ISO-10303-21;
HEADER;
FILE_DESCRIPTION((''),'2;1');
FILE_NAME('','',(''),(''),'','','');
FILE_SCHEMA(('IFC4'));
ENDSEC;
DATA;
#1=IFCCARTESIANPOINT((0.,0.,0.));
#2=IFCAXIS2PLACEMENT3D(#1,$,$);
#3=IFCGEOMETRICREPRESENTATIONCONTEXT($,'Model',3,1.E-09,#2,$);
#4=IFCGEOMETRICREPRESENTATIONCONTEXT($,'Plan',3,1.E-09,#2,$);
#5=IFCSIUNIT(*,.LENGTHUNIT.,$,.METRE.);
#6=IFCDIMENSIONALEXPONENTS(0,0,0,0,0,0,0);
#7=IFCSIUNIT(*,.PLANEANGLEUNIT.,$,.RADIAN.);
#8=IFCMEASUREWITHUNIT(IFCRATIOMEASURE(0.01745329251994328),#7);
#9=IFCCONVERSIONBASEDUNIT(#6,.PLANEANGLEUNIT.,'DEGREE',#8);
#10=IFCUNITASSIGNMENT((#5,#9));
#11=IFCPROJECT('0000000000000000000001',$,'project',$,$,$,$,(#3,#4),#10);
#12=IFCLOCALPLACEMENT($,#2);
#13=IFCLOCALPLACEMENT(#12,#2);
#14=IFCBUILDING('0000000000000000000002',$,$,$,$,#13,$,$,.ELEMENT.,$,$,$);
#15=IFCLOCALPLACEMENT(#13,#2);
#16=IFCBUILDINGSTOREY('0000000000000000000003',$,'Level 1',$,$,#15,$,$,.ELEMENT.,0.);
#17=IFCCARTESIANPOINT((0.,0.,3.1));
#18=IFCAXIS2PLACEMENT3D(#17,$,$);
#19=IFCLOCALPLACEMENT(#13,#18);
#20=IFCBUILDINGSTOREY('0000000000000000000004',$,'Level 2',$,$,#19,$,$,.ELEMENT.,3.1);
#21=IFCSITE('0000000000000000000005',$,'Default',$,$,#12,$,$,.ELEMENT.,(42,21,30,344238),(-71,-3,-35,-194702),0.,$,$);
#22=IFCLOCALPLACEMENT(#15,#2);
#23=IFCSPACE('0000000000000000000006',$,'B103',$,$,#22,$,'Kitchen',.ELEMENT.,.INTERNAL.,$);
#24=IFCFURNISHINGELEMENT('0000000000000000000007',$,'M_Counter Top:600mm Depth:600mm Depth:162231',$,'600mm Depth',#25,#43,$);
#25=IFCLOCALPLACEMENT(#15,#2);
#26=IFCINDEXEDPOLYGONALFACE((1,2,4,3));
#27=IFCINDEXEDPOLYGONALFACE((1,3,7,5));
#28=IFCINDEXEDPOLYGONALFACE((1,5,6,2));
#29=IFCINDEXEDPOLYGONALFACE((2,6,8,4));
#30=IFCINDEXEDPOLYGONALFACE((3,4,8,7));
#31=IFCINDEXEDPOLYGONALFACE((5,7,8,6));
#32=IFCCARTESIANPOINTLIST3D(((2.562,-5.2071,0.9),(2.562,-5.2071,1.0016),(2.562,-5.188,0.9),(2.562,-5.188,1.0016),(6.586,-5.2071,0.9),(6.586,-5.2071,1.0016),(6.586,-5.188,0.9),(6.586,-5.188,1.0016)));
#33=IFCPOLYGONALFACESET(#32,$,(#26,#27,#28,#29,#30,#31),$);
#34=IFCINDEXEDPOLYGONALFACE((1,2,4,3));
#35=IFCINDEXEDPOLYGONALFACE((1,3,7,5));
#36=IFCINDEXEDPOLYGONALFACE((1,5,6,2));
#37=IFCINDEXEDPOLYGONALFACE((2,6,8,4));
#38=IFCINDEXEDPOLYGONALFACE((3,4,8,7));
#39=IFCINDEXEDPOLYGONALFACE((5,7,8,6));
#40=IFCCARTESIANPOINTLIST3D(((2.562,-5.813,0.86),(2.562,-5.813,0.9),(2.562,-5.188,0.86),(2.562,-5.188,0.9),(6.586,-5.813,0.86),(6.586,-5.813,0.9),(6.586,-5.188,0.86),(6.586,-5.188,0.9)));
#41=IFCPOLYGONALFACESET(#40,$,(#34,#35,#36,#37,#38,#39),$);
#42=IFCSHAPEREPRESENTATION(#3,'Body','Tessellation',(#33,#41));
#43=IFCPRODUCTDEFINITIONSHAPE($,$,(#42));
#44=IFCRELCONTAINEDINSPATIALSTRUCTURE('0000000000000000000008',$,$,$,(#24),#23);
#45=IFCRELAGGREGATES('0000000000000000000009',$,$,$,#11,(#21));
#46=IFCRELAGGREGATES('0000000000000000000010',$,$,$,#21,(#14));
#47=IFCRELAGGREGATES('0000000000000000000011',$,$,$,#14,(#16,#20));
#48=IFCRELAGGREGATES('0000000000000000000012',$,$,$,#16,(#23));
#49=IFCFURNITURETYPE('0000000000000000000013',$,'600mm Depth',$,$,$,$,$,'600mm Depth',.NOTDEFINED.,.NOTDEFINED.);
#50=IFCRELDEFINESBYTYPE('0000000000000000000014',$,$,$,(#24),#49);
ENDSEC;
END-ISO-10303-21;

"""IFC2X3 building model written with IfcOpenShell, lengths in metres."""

from ifc_helpers import new_model, entity, si_unit, converted_unit, frame, origin, origin_2d_with_axis, place, context, project, spatial, rectangle, extrude, source, transform, mapped, type_object, type_shapes, element, save


model = new_model("IFC2X3")

# Units and contexts
model_context = context("Model", 3, precision=1e-09, world=origin())
plan_context = context("Plan", 3, precision=1e-09, world=origin())
ifc_project = project(units=[si_unit("LENGTHUNIT", "METRE"), converted_unit("PLANEANGLEUNIT", "DEGREE", entity("IfcRatioMeasure", 0.01745329251994328), si_unit("PLANEANGLEUNIT", "RADIAN"), dimensions=[0, 0, 0, 0, 0, 0, 0])], contexts=[model_context, plan_context])

# Site, building, storey
site_placement = place(None, origin())
site = spatial("IfcSite", under=ifc_project, at=site_placement, Name="Default", CompositionType="ELEMENT", RefLatitude=(42, 21, 30, 344238), RefLongitude=(-71, -3, -35, -194702), RefElevation=0.0)
building_placement = place(site_placement, origin())
building = spatial("IfcBuilding", under=site, at=building_placement, CompositionType="ELEMENT")
storey_1_placement = place(building_placement, origin())
storey_1 = spatial("IfcBuildingStorey", under=building, at=storey_1_placement, Name="Level 1", CompositionType="ELEMENT", Elevation=0.0)

# Shared definitions
storey_2_placement = place(building_placement, frame((0.0, 0.0, 3.1)))
storey_2 = spatial("IfcBuildingStorey", under=building, at=storey_2_placement, Name="Level 2", CompositionType="ELEMENT", Elevation=3.1)

# Shared definitions
space_1_placement = place(storey_1_placement, origin())
space_1 = spatial("IfcSpace", under=storey_1, at=space_1_placement, Name="B103", LongName="Kitchen", CompositionType="ELEMENT", InteriorOrExteriorSpace="INTERNAL")

# Furnishing element
furniture_type_1 = type_object("IfcFurnitureType", Name="600mm Depth", ElementType="600mm Depth", AssemblyPlace="NOTDEFINED")
shared_shape_1 = source(origin(), model_context, "Body", "SweptSolid", [
    extrude(rectangle(XDim=0.0191, YDim=4.024, at=origin_2d_with_axis()), frame((0.8115, -0.0095, 0.9), z_axis=(0.0, 0.0, 1.0), x_axis=(0.0, -1.0, 0.0)), (0.0, 0.0, 1.0), 0.1016),
    extrude(rectangle(XDim=4.024, YDim=0.625, at=origin_2d_with_axis()), frame((0.8115, -0.3125, 0.86), z_axis=(0.0, 0.0, 1.0), x_axis=(-1.0, 0.0, 0.0)), (0.0, 0.0, 1.0), 0.04),
])
type_shapes(furniture_type_1, [shared_shape_1])
furnishing_1_placement = place(space_1_placement, frame((3.7625, -5.188, 0.0)))
element("IfcFurnishingElement", 1, at=furnishing_1_placement, inside=space_1, type_object=furniture_type_1, Name="M_Counter Top:600mm Depth:600mm Depth:162231", ObjectType="600mm Depth", context=model_context, shape_type="MappedRepresentation", body=[
    mapped(shared_shape_1, transform((0.0, 0.0, 0.0), scale=1.0)),
])

save(model, "model.ifc")
